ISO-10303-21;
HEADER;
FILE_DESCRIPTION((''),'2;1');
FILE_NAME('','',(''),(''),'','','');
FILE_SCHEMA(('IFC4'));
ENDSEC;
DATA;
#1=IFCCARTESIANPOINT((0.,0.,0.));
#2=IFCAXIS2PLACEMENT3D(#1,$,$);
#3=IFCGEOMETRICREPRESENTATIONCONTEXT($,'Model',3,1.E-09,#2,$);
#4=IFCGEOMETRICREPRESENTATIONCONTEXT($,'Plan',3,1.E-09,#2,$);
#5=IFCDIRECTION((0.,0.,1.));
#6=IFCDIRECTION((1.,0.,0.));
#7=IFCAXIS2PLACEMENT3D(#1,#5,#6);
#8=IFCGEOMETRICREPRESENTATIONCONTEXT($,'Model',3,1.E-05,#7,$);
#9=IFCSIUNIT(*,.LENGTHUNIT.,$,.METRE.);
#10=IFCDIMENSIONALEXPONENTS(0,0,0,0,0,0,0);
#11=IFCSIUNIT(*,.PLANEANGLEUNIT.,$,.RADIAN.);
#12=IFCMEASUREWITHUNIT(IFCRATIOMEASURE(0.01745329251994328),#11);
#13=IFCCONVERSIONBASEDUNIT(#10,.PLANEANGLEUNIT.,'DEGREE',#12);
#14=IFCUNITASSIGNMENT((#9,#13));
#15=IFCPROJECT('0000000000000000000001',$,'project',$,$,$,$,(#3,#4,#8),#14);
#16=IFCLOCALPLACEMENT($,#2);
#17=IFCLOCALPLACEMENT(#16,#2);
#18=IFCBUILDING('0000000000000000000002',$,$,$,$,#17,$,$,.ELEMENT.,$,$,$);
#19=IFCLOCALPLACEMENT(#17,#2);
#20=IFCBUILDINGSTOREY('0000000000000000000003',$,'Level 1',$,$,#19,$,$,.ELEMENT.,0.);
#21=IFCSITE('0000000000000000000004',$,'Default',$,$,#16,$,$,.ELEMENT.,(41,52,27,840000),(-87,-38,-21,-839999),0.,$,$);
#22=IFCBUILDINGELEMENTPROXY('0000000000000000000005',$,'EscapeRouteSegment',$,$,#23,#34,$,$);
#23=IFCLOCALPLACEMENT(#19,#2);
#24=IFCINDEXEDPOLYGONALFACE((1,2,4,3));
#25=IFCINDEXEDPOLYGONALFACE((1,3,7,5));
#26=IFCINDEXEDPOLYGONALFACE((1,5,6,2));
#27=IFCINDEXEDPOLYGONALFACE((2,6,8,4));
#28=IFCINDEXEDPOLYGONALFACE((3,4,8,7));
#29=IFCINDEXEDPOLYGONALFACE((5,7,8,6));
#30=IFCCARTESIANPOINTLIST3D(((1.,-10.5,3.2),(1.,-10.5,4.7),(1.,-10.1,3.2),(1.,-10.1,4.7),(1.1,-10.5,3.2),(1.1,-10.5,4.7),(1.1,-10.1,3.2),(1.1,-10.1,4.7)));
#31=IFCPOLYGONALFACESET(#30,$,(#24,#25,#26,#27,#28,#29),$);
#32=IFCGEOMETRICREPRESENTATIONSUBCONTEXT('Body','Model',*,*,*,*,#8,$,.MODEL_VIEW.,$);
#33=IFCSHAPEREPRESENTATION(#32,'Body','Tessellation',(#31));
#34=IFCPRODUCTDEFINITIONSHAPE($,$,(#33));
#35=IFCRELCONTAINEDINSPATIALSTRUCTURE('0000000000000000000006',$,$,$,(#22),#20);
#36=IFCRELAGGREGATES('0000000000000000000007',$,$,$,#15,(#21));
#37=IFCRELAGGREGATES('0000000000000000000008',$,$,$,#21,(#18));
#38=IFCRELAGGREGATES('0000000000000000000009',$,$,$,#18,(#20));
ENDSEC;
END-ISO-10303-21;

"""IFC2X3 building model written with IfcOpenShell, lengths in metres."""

from ifc_helpers import new_model, entity, si_unit, converted_unit, frame, origin, origin_with_axes, place, context, subcontext, project, spatial, polyline, outline, extrude, element, save


model = new_model("IFC2X3")

# Units and contexts
model_context_1 = context("Model", 3, precision=1e-09, world=origin())
plan_context = context("Plan", 3, precision=1e-09, world=origin())
model_context_2 = context("Model", 3, precision=1e-05, world=origin_with_axes())
body_context = subcontext(model_context_2, "Body", "Model", "MODEL_VIEW")
ifc_project = project(units=[si_unit("LENGTHUNIT", "METRE"), converted_unit("PLANEANGLEUNIT", "DEGREE", entity("IfcRatioMeasure", 0.01745329251994328), si_unit("PLANEANGLEUNIT", "RADIAN"), dimensions=[0, 0, 0, 0, 0, 0, 0])], contexts=[model_context_1, plan_context, model_context_2])

# Site, building, storey
site_placement = place(None, origin())
site = spatial("IfcSite", under=ifc_project, at=site_placement, Name="Default", CompositionType="ELEMENT", RefLatitude=(41, 52, 27, 840000), RefLongitude=(-87, -38, -21, -839999), RefElevation=0.0)
building_placement = place(site_placement, origin())
building = spatial("IfcBuilding", under=site, at=building_placement, CompositionType="ELEMENT")
storey_placement = place(building_placement, origin())
storey = spatial("IfcBuildingStorey", under=building, at=storey_placement, Name="Level 1", CompositionType="ELEMENT", Elevation=0.0)

# Building element proxy
for number, where, z_axis, x_axis, name in (
    (1, (1.1, -10.3, 3.2), (0.0, 0.0, 1.0), (-1.0, 0.0, 0.0), "EscapeRouteSegment"),
):
    element("IfcBuildingElementProxy", number, at=place(storey_placement, frame(where, z_axis=z_axis, x_axis=x_axis)), inside=storey, Name=name, context=body_context, shape_type="SweptSolid", body=[
        extrude(outline(polyline([(0.0, -0.2), (0.0, 0.2), (0.1, 0.2), (0.1, -0.2), (0.0, -0.2)])), origin_with_axes(), (0.0, 0.0, 1.0), 1.5),
    ])

save(model, "model.ifc")
